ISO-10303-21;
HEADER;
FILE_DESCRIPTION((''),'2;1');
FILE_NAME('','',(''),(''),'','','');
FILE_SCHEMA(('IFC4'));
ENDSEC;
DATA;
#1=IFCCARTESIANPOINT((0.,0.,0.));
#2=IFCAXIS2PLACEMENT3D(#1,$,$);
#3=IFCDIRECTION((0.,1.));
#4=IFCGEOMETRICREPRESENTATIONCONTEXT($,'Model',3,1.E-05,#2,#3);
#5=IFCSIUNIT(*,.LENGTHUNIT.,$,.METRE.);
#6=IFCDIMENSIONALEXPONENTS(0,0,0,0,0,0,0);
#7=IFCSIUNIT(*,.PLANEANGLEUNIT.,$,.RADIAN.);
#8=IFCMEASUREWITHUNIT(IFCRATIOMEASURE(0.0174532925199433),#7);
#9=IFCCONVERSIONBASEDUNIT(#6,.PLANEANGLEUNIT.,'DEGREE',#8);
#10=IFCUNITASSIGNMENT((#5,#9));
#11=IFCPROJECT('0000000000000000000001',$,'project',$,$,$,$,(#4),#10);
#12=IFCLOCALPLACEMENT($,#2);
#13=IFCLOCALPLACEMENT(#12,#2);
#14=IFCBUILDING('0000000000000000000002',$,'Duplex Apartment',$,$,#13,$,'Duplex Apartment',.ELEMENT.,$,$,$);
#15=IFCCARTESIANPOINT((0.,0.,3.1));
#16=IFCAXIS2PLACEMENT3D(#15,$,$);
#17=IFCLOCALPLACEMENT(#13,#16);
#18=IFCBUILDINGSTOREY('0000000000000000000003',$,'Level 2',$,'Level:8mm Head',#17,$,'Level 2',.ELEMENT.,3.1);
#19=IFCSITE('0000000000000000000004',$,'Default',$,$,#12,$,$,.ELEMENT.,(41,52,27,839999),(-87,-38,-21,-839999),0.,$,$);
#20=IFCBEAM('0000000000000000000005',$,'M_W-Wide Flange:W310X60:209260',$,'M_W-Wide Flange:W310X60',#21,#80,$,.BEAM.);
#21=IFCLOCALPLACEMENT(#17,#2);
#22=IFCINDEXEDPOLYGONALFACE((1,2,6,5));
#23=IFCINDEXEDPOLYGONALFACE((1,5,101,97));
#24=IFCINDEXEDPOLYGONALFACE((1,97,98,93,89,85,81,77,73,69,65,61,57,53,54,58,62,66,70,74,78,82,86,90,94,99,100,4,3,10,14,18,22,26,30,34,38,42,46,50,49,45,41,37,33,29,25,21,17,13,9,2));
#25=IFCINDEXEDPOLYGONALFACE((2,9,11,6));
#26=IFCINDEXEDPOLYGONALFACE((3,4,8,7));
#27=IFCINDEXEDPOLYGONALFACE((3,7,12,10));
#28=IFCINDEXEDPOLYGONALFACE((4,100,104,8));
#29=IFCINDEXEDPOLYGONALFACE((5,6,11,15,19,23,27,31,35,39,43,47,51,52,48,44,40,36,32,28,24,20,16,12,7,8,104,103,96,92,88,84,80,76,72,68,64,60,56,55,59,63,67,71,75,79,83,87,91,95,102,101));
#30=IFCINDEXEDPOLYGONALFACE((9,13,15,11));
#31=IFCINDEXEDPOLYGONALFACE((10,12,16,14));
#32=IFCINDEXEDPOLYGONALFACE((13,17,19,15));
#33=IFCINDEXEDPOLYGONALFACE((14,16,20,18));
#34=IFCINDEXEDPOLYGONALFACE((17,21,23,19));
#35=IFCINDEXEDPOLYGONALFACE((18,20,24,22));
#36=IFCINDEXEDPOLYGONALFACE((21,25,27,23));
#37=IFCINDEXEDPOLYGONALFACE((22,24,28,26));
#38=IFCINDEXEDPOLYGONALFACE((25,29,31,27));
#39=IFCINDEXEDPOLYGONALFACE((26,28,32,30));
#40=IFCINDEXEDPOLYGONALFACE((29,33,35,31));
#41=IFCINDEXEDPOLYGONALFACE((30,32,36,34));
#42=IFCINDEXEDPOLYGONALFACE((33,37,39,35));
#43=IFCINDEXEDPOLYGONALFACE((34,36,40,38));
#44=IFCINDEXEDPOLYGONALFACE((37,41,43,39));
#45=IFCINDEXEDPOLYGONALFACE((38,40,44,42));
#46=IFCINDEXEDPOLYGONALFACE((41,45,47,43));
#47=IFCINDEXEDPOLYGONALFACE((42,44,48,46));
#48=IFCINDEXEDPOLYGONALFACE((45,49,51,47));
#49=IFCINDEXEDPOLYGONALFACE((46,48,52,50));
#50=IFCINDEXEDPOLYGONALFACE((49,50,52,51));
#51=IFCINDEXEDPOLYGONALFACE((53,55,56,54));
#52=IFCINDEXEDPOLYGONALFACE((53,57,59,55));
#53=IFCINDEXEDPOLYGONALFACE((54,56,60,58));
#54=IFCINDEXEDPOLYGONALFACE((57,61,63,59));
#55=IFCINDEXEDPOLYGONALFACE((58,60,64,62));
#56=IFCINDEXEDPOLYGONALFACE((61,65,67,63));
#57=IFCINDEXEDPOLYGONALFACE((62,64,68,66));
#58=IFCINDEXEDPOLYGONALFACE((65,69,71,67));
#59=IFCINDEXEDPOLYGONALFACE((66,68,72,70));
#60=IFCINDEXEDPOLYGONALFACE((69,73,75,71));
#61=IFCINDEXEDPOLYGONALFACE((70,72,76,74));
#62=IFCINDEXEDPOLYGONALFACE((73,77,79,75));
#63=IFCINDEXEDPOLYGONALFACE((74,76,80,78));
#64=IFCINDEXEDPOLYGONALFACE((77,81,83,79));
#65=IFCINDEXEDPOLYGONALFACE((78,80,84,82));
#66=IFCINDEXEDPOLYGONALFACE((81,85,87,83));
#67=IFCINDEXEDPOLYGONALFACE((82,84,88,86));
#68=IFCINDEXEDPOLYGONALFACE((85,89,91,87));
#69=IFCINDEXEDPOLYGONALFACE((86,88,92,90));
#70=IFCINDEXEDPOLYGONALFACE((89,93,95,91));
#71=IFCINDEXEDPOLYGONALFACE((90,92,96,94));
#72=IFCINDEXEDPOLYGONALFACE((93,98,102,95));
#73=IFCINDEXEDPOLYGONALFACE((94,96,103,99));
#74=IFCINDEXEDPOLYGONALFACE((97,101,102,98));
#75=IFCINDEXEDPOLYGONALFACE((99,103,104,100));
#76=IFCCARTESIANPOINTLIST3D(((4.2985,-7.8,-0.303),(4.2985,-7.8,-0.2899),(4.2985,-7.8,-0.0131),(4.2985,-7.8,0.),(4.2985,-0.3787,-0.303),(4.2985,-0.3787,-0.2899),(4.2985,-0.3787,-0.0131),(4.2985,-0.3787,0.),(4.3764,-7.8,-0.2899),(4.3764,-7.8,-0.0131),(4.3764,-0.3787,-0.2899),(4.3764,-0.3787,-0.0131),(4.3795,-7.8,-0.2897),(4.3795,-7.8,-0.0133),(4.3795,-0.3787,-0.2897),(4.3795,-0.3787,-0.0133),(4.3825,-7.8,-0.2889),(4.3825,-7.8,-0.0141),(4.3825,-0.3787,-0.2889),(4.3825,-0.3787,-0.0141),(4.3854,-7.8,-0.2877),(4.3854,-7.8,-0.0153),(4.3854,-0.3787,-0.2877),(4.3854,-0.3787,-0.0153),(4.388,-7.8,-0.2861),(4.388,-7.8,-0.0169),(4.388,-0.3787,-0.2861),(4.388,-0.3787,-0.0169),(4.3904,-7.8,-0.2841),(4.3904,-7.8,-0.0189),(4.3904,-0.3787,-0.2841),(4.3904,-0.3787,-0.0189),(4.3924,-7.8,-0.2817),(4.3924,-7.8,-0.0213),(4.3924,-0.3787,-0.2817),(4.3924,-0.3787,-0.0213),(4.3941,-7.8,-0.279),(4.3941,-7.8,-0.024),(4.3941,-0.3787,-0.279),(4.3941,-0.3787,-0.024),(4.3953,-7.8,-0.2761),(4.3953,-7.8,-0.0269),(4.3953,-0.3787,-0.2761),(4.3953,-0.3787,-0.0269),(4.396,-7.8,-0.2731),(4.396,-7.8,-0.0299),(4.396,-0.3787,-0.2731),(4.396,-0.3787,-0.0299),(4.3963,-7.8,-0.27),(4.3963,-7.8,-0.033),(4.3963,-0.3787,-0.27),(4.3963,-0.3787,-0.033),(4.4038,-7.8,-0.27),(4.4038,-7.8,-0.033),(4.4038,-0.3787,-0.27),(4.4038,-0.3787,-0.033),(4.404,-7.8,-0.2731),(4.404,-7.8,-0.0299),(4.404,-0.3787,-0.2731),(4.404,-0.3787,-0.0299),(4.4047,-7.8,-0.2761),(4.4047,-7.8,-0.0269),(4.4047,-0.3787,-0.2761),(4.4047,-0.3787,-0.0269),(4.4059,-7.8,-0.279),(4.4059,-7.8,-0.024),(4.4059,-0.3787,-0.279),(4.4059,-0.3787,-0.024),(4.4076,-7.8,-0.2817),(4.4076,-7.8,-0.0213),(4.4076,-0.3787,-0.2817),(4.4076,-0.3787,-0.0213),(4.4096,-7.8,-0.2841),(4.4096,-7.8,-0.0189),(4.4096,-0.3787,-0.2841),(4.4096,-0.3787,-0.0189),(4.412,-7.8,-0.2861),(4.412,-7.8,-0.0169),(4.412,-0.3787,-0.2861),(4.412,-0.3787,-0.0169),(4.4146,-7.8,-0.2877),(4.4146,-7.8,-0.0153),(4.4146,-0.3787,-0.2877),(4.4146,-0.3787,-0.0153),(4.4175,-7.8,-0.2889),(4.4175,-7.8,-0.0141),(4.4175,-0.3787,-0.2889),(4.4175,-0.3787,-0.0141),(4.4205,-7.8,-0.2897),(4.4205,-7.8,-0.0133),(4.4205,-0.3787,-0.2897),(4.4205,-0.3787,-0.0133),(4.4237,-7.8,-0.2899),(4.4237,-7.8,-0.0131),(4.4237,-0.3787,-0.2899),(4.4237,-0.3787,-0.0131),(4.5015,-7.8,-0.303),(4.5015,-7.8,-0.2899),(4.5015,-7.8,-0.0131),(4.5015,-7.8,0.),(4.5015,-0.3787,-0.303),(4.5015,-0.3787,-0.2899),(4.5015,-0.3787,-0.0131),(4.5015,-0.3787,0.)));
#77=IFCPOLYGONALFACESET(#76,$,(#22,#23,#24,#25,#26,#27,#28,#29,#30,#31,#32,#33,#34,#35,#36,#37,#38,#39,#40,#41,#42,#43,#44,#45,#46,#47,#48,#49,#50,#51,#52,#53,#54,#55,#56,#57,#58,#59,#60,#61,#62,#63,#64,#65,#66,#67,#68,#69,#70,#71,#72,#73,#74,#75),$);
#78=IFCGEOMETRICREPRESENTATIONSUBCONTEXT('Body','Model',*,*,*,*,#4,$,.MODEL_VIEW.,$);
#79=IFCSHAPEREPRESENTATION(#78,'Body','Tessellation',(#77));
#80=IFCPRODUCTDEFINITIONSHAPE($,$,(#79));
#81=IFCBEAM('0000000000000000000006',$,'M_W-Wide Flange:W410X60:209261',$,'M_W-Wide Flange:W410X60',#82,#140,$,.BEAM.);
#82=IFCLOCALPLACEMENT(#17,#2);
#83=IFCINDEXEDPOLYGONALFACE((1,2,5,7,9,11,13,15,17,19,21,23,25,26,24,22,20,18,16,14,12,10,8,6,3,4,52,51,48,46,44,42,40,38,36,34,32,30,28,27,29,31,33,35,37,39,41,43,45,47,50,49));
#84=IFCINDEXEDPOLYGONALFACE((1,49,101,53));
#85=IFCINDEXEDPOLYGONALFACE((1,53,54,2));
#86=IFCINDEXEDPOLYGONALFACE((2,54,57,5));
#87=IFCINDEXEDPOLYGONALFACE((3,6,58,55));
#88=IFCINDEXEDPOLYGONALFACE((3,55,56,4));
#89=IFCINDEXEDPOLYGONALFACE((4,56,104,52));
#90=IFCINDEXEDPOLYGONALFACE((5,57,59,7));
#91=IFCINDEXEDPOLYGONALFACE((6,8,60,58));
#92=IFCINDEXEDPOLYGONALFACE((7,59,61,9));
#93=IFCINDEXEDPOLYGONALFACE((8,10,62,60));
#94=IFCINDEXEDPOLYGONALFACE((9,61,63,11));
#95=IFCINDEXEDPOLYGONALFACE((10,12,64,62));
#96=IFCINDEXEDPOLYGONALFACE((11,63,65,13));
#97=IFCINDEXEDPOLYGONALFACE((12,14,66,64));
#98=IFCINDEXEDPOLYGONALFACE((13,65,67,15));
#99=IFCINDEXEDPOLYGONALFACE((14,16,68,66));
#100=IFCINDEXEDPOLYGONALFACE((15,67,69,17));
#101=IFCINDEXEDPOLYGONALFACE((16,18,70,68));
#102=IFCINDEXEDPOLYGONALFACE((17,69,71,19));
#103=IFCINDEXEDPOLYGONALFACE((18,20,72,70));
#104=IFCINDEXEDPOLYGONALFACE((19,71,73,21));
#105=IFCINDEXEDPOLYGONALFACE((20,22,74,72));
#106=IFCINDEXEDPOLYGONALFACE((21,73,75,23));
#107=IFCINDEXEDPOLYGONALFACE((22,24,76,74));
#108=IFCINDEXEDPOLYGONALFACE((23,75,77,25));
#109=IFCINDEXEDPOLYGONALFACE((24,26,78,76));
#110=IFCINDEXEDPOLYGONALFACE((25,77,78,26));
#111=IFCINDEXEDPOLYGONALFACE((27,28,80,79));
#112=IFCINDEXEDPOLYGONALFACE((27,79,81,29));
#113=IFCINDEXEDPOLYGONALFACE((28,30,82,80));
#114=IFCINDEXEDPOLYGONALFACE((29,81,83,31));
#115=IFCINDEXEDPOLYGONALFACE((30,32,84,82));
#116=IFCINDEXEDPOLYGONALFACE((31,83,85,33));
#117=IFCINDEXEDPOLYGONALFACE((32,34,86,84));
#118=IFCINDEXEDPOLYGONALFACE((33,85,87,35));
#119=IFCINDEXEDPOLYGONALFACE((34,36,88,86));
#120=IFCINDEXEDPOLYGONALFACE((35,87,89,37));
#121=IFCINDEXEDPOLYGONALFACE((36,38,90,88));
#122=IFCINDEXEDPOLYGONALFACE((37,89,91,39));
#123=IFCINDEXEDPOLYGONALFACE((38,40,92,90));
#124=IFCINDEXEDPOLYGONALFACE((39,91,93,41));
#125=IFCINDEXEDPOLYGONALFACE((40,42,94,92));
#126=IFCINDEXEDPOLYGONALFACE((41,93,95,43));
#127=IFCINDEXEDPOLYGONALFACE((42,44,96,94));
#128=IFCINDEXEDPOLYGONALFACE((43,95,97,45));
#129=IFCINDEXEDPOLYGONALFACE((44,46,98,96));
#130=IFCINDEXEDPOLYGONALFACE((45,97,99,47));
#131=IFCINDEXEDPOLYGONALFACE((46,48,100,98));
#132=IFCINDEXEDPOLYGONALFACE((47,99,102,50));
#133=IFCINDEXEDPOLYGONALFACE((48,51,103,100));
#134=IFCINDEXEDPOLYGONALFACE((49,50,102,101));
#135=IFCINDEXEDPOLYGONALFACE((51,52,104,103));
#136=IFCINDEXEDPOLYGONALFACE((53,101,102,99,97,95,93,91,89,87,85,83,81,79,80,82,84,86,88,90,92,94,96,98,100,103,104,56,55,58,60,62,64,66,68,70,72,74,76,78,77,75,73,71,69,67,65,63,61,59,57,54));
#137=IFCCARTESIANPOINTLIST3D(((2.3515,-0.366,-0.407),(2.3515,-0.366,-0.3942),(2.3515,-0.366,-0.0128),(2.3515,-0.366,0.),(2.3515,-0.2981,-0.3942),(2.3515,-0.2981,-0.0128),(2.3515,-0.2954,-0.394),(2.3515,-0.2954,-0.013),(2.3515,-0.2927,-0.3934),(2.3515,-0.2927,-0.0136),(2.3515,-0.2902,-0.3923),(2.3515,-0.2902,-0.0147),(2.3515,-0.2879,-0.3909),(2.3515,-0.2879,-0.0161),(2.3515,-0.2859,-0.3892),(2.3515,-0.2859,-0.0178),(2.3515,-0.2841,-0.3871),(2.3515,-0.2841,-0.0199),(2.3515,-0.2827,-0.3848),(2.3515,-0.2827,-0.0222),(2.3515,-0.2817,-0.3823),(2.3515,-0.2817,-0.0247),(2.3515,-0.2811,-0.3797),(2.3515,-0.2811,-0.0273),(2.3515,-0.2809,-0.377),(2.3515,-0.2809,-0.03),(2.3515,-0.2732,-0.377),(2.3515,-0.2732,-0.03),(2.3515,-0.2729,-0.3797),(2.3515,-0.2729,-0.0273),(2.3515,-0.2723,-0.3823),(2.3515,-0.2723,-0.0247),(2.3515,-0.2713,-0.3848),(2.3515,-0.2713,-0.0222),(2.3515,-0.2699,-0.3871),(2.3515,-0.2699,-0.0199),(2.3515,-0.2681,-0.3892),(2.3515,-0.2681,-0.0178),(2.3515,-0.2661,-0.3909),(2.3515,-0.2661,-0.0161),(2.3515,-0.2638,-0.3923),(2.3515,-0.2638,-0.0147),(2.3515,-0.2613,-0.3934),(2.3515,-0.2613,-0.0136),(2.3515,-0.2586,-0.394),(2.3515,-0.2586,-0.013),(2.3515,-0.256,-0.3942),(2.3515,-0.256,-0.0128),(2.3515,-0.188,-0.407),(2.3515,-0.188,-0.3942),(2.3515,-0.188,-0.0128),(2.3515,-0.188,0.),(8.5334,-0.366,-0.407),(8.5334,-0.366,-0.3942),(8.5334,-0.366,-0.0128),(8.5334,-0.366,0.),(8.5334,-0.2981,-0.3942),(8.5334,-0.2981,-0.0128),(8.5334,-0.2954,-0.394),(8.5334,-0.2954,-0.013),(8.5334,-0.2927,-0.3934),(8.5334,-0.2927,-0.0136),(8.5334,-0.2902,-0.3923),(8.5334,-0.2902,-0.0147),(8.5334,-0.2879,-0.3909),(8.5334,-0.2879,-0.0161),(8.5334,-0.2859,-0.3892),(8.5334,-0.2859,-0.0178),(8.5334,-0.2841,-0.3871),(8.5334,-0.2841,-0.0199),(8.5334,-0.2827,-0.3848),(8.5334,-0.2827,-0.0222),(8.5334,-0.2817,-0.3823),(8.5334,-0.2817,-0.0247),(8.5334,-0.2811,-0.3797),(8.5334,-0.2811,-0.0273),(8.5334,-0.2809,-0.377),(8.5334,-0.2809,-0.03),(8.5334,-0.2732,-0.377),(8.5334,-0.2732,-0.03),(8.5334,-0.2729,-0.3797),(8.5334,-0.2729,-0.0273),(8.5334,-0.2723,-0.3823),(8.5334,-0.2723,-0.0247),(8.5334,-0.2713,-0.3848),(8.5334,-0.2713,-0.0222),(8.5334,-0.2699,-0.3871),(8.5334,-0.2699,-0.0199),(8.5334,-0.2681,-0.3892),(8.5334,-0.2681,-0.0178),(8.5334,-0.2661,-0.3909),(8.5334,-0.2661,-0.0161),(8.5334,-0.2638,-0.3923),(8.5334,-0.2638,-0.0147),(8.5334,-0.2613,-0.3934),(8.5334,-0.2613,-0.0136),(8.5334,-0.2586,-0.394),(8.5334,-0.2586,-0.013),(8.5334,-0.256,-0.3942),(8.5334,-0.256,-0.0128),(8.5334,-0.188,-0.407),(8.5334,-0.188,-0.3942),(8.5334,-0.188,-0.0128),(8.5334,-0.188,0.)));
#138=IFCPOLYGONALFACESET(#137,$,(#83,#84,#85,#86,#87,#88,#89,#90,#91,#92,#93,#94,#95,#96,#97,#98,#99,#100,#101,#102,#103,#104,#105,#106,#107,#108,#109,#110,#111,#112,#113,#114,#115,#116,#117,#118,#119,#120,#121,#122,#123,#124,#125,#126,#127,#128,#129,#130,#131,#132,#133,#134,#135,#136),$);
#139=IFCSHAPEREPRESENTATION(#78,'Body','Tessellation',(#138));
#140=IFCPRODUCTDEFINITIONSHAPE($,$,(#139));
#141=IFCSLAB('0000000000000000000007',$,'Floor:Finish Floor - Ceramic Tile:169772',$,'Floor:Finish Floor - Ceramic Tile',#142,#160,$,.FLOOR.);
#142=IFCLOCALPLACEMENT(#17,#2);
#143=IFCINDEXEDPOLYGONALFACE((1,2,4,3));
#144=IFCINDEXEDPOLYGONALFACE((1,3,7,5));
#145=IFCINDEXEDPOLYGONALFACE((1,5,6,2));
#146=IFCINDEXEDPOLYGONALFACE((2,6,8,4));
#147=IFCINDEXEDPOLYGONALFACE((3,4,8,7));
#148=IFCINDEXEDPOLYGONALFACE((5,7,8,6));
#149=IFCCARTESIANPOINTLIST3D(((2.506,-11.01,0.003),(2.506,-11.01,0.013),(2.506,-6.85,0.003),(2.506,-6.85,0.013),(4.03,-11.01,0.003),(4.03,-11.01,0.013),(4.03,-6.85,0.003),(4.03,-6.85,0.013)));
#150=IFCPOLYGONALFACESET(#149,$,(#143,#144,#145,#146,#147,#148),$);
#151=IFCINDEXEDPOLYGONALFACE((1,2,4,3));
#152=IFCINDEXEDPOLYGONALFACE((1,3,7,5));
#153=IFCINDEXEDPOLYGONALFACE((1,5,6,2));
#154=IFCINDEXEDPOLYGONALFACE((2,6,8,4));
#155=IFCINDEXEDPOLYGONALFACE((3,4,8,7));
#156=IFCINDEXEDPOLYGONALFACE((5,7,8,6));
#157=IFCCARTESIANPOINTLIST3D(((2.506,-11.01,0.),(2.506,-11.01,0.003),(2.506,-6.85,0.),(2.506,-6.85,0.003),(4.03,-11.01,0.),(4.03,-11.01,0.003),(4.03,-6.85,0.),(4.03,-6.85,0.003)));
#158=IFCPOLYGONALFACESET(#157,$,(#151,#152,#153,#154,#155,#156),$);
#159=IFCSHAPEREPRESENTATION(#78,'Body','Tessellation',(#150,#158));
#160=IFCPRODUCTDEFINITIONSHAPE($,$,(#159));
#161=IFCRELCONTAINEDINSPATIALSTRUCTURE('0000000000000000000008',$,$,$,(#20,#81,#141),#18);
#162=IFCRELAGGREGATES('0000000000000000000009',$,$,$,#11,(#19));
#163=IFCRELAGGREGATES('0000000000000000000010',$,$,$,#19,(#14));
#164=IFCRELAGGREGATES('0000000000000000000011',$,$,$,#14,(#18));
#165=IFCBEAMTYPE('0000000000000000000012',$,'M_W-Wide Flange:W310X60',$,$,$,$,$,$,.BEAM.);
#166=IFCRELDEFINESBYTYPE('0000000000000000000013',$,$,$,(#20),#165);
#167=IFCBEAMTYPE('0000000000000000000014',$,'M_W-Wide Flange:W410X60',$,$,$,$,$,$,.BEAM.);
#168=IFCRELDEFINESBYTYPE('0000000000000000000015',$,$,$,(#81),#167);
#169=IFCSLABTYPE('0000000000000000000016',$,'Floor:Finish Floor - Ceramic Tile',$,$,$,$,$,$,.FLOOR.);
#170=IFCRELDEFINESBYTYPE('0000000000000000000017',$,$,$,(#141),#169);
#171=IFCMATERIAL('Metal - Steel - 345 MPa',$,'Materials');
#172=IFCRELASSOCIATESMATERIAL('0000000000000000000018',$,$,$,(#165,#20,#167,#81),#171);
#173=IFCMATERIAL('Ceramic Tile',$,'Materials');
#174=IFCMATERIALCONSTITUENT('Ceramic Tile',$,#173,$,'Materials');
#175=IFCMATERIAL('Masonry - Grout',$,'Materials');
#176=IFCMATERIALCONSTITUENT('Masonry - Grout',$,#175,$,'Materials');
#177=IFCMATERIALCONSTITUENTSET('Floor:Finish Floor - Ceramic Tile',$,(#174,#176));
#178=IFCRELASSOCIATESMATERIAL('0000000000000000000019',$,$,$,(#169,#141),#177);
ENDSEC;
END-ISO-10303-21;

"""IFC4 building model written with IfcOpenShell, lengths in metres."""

from ifc_helpers import new_model, entity, si_unit, converted_unit, direction, frame, origin, place, context, subcontext, project, spatial, indexed_curve, outline, extrude, source, transform, mapped, material, constituent, constituent_set, type_object, type_shapes, element, save


model = new_model("IFC4")

# Units and contexts
model_context = context("Model", 3, precision=1e-05, world=origin(), true_north=direction((0.0, 1.0)))
body_context = subcontext(model_context, "Body", "Model", "MODEL_VIEW")
ifc_project = project(units=[si_unit("LENGTHUNIT", "METRE"), converted_unit("PLANEANGLEUNIT", "DEGREE", entity("IfcRatioMeasure", 0.0174532925199433), si_unit("PLANEANGLEUNIT", "RADIAN"), dimensions=[0, 0, 0, 0, 0, 0, 0])], contexts=[model_context])

# Site, building, storey
site_placement = place(None, origin())
site = spatial("IfcSite", under=ifc_project, at=site_placement, Name="Default", CompositionType="ELEMENT", RefLatitude=(41, 52, 27, 839999), RefLongitude=(-87, -38, -21, -839999), RefElevation=0.0)
building_placement = place(site_placement, origin())
building = spatial("IfcBuilding", under=site, at=building_placement, Name="Duplex Apartment", LongName="Duplex Apartment", CompositionType="ELEMENT")
storey_placement = place(building_placement, frame((0.0, 0.0, 3.1)))
storey = spatial("IfcBuildingStorey", under=building, at=storey_placement, Name="Level 2", ObjectType="Level:8mm Head", LongName="Level 2", CompositionType="ELEMENT", Elevation=3.1)

# Beams
ifc_material_1 = material(Name="Metal - Steel - 345 MPa", Category="Materials")
beam_type_1 = type_object("IfcBeamType", Name="M_W-Wide Flange:W310X60", PredefinedType="BEAM", material=ifc_material_1)
shared_shape_1 = source(origin(), body_context, "Body", "SweptSolid", [
    extrude(outline(indexed_curve([(-0.1515, -0.1015), (-0.1384, -0.1015), (-0.1384, -0.0237), (-0.1382, -0.0205), (-0.1374, -0.0175), (-0.1362, -0.0146), (-0.1346, -0.012), (-0.1326, -0.0096), (-0.1302, -0.0076), (-0.1275, -0.0059), (-0.1246, -0.0047), (-0.1216, -0.004), (-0.1185, -0.0037), (0.1185, -0.0037), (0.1216, -0.004), (0.1246, -0.0047), (0.1275, -0.0059), (0.1302, -0.0076), (0.1326, -0.0096), (0.1346, -0.012), (0.1362, -0.0146), (0.1374, -0.0175), (0.1382, -0.0205), (0.1384, -0.0236), (0.1384, -0.1015), (0.1515, -0.1015), (0.1515, 0.1015), (0.1384, 0.1015), (0.1384, 0.0237), (0.1382, 0.0205), (0.1374, 0.0175), (0.1362, 0.0146), (0.1346, 0.012), (0.1326, 0.0096), (0.1302, 0.0076), (0.1275, 0.0059), (0.1246, 0.0047), (0.1216, 0.004), (0.1185, 0.0038), (-0.1185, 0.0038), (-0.1216, 0.004), (-0.1246, 0.0047), (-0.1275, 0.0059), (-0.1302, 0.0076), (-0.1326, 0.0096), (-0.1346, 0.012), (-0.1362, 0.0146), (-0.1374, 0.0175), (-0.1382, 0.0205), (-0.1384, 0.0237), (-0.1384, 0.1015), (-0.1515, 0.1015), (-0.1515, -0.1015)], self_intersect=False)), frame((-3.7615, 0.0, 0.0), z_axis=(1.0, 0.0, 0.0), x_axis=(0.0, 0.0, -1.0)), (0.0, 0.0, 1.0), 7.4213),
])
type_shapes(beam_type_1, [shared_shape_1])
beam_1_placement = place(storey_placement, frame((4.4, -4.0385, -0.1515), z_axis=(0.0, 0.0, 1.0), x_axis=(0.0, 1.0, 0.0)))
element("IfcBeam", 1, at=beam_1_placement, inside=storey, type_object=beam_type_1, material=ifc_material_1, Name="M_W-Wide Flange:W310X60:209260", ObjectType="M_W-Wide Flange:W310X60", PredefinedType="BEAM", context=body_context, shape_type="MappedRepresentation", body=[
    mapped(shared_shape_1, transform((0.0, 0.0, 0.0), scale=1.0)),
])
beam_type_2 = type_object("IfcBeamType", Name="M_W-Wide Flange:W410X60", PredefinedType="BEAM", material=ifc_material_1)
shared_shape_2 = source(origin(), body_context, "Body", "SweptSolid", [
    extrude(outline(indexed_curve([(-0.2035, -0.089), (-0.1907, -0.089), (-0.1907, -0.021), (-0.1905, -0.0184), (-0.1899, -0.0157), (-0.1888, -0.0132), (-0.1874, -0.0109), (-0.1857, -0.0089), (-0.1836, -0.0071), (-0.1813, -0.0057), (-0.1788, -0.0047), (-0.1762, -0.0041), (-0.1735, -0.0038), (0.1735, -0.0038), (0.1762, -0.0041), (0.1788, -0.0047), (0.1813, -0.0057), (0.1836, -0.0071), (0.1857, -0.0089), (0.1874, -0.0109), (0.1888, -0.0132), (0.1899, -0.0157), (0.1905, -0.0184), (0.1907, -0.021), (0.1907, -0.089), (0.2035, -0.089), (0.2035, 0.089), (0.1907, 0.089), (0.1907, 0.0211), (0.1905, 0.0184), (0.1899, 0.0157), (0.1888, 0.0132), (0.1874, 0.0109), (0.1857, 0.0089), (0.1836, 0.0071), (0.1813, 0.0057), (0.1788, 0.0047), (0.1762, 0.0041), (0.1735, 0.0039), (-0.1735, 0.0039), (-0.1762, 0.0041), (-0.1788, 0.0047), (-0.1813, 0.0057), (-0.1836, 0.0071), (-0.1857, 0.0089), (-0.1874, 0.0109), (-0.1888, 0.0132), (-0.1899, 0.0157), (-0.1905, 0.0184), (-0.1907, 0.0211), (-0.1907, 0.089), (-0.2035, 0.089), (-0.2035, -0.089)], self_intersect=False)), frame((-3.0909, 0.0, 0.0), z_axis=(1.0, 0.0, 0.0), x_axis=(0.0, 0.0, -1.0)), (0.0, 0.0, 1.0), 6.1819),
])
type_shapes(beam_type_2, [shared_shape_2])
beam_2_placement = place(storey_placement, frame((5.4424, -0.277, -0.2035), z_axis=(0.0, 0.0, 1.0), x_axis=(-1.0, 0.0, 0.0)))
element("IfcBeam", 2, at=beam_2_placement, inside=storey, type_object=beam_type_2, material=ifc_material_1, Name="M_W-Wide Flange:W410X60:209261", ObjectType="M_W-Wide Flange:W410X60", PredefinedType="BEAM", context=body_context, shape_type="MappedRepresentation", body=[
    mapped(shared_shape_2, transform((0.0, 0.0, 0.0), scale=1.0)),
])

# Slab
ifc_material_2 = material(Name="Ceramic Tile", Category="Materials")
ifc_constituent_1 = constituent(ifc_material_2, Name="Ceramic Tile", Category="Materials")
ifc_material_3 = material(Name="Masonry - Grout", Category="Materials")
ifc_constituent_2 = constituent(ifc_material_3, Name="Masonry - Grout", Category="Materials")
ifc_constituent_set_1 = constituent_set(constituents=[ifc_constituent_1, ifc_constituent_2], Name="Floor:Finish Floor - Ceramic Tile")
slab_type_1 = type_object("IfcSlabType", Name="Floor:Finish Floor - Ceramic Tile", PredefinedType="FLOOR", material=ifc_constituent_set_1)
slab_1_placement = place(storey_placement, origin())
element("IfcSlab", 3, at=slab_1_placement, inside=storey, type_object=slab_type_1, material=ifc_constituent_set_1, Name="Floor:Finish Floor - Ceramic Tile:169772", ObjectType="Floor:Finish Floor - Ceramic Tile", PredefinedType="FLOOR", context=body_context, shape_type="SweptSolid", body=[
    extrude(outline(indexed_curve([(-0.762, -2.08), (0.762, -2.08), (0.762, 2.08), (-0.762, 2.08), (-0.762, -2.08)], self_intersect=False)), frame((3.268, -8.93, 0.003), z_axis=(0.0, 0.0, 1.0), x_axis=(-1.0, 0.0, 0.0)), (0.0, 0.0, 1.0), 0.01),
    extrude(outline(indexed_curve([(-0.762, -2.08), (0.762, -2.08), (0.762, 2.08), (-0.762, 2.08), (-0.762, -2.08)], self_intersect=False)), frame((3.268, -8.93, 0.0), z_axis=(0.0, 0.0, 1.0), x_axis=(-1.0, 0.0, 0.0)), (0.0, 0.0, 1.0), 0.003),
])

save(model, "model.ifc")
